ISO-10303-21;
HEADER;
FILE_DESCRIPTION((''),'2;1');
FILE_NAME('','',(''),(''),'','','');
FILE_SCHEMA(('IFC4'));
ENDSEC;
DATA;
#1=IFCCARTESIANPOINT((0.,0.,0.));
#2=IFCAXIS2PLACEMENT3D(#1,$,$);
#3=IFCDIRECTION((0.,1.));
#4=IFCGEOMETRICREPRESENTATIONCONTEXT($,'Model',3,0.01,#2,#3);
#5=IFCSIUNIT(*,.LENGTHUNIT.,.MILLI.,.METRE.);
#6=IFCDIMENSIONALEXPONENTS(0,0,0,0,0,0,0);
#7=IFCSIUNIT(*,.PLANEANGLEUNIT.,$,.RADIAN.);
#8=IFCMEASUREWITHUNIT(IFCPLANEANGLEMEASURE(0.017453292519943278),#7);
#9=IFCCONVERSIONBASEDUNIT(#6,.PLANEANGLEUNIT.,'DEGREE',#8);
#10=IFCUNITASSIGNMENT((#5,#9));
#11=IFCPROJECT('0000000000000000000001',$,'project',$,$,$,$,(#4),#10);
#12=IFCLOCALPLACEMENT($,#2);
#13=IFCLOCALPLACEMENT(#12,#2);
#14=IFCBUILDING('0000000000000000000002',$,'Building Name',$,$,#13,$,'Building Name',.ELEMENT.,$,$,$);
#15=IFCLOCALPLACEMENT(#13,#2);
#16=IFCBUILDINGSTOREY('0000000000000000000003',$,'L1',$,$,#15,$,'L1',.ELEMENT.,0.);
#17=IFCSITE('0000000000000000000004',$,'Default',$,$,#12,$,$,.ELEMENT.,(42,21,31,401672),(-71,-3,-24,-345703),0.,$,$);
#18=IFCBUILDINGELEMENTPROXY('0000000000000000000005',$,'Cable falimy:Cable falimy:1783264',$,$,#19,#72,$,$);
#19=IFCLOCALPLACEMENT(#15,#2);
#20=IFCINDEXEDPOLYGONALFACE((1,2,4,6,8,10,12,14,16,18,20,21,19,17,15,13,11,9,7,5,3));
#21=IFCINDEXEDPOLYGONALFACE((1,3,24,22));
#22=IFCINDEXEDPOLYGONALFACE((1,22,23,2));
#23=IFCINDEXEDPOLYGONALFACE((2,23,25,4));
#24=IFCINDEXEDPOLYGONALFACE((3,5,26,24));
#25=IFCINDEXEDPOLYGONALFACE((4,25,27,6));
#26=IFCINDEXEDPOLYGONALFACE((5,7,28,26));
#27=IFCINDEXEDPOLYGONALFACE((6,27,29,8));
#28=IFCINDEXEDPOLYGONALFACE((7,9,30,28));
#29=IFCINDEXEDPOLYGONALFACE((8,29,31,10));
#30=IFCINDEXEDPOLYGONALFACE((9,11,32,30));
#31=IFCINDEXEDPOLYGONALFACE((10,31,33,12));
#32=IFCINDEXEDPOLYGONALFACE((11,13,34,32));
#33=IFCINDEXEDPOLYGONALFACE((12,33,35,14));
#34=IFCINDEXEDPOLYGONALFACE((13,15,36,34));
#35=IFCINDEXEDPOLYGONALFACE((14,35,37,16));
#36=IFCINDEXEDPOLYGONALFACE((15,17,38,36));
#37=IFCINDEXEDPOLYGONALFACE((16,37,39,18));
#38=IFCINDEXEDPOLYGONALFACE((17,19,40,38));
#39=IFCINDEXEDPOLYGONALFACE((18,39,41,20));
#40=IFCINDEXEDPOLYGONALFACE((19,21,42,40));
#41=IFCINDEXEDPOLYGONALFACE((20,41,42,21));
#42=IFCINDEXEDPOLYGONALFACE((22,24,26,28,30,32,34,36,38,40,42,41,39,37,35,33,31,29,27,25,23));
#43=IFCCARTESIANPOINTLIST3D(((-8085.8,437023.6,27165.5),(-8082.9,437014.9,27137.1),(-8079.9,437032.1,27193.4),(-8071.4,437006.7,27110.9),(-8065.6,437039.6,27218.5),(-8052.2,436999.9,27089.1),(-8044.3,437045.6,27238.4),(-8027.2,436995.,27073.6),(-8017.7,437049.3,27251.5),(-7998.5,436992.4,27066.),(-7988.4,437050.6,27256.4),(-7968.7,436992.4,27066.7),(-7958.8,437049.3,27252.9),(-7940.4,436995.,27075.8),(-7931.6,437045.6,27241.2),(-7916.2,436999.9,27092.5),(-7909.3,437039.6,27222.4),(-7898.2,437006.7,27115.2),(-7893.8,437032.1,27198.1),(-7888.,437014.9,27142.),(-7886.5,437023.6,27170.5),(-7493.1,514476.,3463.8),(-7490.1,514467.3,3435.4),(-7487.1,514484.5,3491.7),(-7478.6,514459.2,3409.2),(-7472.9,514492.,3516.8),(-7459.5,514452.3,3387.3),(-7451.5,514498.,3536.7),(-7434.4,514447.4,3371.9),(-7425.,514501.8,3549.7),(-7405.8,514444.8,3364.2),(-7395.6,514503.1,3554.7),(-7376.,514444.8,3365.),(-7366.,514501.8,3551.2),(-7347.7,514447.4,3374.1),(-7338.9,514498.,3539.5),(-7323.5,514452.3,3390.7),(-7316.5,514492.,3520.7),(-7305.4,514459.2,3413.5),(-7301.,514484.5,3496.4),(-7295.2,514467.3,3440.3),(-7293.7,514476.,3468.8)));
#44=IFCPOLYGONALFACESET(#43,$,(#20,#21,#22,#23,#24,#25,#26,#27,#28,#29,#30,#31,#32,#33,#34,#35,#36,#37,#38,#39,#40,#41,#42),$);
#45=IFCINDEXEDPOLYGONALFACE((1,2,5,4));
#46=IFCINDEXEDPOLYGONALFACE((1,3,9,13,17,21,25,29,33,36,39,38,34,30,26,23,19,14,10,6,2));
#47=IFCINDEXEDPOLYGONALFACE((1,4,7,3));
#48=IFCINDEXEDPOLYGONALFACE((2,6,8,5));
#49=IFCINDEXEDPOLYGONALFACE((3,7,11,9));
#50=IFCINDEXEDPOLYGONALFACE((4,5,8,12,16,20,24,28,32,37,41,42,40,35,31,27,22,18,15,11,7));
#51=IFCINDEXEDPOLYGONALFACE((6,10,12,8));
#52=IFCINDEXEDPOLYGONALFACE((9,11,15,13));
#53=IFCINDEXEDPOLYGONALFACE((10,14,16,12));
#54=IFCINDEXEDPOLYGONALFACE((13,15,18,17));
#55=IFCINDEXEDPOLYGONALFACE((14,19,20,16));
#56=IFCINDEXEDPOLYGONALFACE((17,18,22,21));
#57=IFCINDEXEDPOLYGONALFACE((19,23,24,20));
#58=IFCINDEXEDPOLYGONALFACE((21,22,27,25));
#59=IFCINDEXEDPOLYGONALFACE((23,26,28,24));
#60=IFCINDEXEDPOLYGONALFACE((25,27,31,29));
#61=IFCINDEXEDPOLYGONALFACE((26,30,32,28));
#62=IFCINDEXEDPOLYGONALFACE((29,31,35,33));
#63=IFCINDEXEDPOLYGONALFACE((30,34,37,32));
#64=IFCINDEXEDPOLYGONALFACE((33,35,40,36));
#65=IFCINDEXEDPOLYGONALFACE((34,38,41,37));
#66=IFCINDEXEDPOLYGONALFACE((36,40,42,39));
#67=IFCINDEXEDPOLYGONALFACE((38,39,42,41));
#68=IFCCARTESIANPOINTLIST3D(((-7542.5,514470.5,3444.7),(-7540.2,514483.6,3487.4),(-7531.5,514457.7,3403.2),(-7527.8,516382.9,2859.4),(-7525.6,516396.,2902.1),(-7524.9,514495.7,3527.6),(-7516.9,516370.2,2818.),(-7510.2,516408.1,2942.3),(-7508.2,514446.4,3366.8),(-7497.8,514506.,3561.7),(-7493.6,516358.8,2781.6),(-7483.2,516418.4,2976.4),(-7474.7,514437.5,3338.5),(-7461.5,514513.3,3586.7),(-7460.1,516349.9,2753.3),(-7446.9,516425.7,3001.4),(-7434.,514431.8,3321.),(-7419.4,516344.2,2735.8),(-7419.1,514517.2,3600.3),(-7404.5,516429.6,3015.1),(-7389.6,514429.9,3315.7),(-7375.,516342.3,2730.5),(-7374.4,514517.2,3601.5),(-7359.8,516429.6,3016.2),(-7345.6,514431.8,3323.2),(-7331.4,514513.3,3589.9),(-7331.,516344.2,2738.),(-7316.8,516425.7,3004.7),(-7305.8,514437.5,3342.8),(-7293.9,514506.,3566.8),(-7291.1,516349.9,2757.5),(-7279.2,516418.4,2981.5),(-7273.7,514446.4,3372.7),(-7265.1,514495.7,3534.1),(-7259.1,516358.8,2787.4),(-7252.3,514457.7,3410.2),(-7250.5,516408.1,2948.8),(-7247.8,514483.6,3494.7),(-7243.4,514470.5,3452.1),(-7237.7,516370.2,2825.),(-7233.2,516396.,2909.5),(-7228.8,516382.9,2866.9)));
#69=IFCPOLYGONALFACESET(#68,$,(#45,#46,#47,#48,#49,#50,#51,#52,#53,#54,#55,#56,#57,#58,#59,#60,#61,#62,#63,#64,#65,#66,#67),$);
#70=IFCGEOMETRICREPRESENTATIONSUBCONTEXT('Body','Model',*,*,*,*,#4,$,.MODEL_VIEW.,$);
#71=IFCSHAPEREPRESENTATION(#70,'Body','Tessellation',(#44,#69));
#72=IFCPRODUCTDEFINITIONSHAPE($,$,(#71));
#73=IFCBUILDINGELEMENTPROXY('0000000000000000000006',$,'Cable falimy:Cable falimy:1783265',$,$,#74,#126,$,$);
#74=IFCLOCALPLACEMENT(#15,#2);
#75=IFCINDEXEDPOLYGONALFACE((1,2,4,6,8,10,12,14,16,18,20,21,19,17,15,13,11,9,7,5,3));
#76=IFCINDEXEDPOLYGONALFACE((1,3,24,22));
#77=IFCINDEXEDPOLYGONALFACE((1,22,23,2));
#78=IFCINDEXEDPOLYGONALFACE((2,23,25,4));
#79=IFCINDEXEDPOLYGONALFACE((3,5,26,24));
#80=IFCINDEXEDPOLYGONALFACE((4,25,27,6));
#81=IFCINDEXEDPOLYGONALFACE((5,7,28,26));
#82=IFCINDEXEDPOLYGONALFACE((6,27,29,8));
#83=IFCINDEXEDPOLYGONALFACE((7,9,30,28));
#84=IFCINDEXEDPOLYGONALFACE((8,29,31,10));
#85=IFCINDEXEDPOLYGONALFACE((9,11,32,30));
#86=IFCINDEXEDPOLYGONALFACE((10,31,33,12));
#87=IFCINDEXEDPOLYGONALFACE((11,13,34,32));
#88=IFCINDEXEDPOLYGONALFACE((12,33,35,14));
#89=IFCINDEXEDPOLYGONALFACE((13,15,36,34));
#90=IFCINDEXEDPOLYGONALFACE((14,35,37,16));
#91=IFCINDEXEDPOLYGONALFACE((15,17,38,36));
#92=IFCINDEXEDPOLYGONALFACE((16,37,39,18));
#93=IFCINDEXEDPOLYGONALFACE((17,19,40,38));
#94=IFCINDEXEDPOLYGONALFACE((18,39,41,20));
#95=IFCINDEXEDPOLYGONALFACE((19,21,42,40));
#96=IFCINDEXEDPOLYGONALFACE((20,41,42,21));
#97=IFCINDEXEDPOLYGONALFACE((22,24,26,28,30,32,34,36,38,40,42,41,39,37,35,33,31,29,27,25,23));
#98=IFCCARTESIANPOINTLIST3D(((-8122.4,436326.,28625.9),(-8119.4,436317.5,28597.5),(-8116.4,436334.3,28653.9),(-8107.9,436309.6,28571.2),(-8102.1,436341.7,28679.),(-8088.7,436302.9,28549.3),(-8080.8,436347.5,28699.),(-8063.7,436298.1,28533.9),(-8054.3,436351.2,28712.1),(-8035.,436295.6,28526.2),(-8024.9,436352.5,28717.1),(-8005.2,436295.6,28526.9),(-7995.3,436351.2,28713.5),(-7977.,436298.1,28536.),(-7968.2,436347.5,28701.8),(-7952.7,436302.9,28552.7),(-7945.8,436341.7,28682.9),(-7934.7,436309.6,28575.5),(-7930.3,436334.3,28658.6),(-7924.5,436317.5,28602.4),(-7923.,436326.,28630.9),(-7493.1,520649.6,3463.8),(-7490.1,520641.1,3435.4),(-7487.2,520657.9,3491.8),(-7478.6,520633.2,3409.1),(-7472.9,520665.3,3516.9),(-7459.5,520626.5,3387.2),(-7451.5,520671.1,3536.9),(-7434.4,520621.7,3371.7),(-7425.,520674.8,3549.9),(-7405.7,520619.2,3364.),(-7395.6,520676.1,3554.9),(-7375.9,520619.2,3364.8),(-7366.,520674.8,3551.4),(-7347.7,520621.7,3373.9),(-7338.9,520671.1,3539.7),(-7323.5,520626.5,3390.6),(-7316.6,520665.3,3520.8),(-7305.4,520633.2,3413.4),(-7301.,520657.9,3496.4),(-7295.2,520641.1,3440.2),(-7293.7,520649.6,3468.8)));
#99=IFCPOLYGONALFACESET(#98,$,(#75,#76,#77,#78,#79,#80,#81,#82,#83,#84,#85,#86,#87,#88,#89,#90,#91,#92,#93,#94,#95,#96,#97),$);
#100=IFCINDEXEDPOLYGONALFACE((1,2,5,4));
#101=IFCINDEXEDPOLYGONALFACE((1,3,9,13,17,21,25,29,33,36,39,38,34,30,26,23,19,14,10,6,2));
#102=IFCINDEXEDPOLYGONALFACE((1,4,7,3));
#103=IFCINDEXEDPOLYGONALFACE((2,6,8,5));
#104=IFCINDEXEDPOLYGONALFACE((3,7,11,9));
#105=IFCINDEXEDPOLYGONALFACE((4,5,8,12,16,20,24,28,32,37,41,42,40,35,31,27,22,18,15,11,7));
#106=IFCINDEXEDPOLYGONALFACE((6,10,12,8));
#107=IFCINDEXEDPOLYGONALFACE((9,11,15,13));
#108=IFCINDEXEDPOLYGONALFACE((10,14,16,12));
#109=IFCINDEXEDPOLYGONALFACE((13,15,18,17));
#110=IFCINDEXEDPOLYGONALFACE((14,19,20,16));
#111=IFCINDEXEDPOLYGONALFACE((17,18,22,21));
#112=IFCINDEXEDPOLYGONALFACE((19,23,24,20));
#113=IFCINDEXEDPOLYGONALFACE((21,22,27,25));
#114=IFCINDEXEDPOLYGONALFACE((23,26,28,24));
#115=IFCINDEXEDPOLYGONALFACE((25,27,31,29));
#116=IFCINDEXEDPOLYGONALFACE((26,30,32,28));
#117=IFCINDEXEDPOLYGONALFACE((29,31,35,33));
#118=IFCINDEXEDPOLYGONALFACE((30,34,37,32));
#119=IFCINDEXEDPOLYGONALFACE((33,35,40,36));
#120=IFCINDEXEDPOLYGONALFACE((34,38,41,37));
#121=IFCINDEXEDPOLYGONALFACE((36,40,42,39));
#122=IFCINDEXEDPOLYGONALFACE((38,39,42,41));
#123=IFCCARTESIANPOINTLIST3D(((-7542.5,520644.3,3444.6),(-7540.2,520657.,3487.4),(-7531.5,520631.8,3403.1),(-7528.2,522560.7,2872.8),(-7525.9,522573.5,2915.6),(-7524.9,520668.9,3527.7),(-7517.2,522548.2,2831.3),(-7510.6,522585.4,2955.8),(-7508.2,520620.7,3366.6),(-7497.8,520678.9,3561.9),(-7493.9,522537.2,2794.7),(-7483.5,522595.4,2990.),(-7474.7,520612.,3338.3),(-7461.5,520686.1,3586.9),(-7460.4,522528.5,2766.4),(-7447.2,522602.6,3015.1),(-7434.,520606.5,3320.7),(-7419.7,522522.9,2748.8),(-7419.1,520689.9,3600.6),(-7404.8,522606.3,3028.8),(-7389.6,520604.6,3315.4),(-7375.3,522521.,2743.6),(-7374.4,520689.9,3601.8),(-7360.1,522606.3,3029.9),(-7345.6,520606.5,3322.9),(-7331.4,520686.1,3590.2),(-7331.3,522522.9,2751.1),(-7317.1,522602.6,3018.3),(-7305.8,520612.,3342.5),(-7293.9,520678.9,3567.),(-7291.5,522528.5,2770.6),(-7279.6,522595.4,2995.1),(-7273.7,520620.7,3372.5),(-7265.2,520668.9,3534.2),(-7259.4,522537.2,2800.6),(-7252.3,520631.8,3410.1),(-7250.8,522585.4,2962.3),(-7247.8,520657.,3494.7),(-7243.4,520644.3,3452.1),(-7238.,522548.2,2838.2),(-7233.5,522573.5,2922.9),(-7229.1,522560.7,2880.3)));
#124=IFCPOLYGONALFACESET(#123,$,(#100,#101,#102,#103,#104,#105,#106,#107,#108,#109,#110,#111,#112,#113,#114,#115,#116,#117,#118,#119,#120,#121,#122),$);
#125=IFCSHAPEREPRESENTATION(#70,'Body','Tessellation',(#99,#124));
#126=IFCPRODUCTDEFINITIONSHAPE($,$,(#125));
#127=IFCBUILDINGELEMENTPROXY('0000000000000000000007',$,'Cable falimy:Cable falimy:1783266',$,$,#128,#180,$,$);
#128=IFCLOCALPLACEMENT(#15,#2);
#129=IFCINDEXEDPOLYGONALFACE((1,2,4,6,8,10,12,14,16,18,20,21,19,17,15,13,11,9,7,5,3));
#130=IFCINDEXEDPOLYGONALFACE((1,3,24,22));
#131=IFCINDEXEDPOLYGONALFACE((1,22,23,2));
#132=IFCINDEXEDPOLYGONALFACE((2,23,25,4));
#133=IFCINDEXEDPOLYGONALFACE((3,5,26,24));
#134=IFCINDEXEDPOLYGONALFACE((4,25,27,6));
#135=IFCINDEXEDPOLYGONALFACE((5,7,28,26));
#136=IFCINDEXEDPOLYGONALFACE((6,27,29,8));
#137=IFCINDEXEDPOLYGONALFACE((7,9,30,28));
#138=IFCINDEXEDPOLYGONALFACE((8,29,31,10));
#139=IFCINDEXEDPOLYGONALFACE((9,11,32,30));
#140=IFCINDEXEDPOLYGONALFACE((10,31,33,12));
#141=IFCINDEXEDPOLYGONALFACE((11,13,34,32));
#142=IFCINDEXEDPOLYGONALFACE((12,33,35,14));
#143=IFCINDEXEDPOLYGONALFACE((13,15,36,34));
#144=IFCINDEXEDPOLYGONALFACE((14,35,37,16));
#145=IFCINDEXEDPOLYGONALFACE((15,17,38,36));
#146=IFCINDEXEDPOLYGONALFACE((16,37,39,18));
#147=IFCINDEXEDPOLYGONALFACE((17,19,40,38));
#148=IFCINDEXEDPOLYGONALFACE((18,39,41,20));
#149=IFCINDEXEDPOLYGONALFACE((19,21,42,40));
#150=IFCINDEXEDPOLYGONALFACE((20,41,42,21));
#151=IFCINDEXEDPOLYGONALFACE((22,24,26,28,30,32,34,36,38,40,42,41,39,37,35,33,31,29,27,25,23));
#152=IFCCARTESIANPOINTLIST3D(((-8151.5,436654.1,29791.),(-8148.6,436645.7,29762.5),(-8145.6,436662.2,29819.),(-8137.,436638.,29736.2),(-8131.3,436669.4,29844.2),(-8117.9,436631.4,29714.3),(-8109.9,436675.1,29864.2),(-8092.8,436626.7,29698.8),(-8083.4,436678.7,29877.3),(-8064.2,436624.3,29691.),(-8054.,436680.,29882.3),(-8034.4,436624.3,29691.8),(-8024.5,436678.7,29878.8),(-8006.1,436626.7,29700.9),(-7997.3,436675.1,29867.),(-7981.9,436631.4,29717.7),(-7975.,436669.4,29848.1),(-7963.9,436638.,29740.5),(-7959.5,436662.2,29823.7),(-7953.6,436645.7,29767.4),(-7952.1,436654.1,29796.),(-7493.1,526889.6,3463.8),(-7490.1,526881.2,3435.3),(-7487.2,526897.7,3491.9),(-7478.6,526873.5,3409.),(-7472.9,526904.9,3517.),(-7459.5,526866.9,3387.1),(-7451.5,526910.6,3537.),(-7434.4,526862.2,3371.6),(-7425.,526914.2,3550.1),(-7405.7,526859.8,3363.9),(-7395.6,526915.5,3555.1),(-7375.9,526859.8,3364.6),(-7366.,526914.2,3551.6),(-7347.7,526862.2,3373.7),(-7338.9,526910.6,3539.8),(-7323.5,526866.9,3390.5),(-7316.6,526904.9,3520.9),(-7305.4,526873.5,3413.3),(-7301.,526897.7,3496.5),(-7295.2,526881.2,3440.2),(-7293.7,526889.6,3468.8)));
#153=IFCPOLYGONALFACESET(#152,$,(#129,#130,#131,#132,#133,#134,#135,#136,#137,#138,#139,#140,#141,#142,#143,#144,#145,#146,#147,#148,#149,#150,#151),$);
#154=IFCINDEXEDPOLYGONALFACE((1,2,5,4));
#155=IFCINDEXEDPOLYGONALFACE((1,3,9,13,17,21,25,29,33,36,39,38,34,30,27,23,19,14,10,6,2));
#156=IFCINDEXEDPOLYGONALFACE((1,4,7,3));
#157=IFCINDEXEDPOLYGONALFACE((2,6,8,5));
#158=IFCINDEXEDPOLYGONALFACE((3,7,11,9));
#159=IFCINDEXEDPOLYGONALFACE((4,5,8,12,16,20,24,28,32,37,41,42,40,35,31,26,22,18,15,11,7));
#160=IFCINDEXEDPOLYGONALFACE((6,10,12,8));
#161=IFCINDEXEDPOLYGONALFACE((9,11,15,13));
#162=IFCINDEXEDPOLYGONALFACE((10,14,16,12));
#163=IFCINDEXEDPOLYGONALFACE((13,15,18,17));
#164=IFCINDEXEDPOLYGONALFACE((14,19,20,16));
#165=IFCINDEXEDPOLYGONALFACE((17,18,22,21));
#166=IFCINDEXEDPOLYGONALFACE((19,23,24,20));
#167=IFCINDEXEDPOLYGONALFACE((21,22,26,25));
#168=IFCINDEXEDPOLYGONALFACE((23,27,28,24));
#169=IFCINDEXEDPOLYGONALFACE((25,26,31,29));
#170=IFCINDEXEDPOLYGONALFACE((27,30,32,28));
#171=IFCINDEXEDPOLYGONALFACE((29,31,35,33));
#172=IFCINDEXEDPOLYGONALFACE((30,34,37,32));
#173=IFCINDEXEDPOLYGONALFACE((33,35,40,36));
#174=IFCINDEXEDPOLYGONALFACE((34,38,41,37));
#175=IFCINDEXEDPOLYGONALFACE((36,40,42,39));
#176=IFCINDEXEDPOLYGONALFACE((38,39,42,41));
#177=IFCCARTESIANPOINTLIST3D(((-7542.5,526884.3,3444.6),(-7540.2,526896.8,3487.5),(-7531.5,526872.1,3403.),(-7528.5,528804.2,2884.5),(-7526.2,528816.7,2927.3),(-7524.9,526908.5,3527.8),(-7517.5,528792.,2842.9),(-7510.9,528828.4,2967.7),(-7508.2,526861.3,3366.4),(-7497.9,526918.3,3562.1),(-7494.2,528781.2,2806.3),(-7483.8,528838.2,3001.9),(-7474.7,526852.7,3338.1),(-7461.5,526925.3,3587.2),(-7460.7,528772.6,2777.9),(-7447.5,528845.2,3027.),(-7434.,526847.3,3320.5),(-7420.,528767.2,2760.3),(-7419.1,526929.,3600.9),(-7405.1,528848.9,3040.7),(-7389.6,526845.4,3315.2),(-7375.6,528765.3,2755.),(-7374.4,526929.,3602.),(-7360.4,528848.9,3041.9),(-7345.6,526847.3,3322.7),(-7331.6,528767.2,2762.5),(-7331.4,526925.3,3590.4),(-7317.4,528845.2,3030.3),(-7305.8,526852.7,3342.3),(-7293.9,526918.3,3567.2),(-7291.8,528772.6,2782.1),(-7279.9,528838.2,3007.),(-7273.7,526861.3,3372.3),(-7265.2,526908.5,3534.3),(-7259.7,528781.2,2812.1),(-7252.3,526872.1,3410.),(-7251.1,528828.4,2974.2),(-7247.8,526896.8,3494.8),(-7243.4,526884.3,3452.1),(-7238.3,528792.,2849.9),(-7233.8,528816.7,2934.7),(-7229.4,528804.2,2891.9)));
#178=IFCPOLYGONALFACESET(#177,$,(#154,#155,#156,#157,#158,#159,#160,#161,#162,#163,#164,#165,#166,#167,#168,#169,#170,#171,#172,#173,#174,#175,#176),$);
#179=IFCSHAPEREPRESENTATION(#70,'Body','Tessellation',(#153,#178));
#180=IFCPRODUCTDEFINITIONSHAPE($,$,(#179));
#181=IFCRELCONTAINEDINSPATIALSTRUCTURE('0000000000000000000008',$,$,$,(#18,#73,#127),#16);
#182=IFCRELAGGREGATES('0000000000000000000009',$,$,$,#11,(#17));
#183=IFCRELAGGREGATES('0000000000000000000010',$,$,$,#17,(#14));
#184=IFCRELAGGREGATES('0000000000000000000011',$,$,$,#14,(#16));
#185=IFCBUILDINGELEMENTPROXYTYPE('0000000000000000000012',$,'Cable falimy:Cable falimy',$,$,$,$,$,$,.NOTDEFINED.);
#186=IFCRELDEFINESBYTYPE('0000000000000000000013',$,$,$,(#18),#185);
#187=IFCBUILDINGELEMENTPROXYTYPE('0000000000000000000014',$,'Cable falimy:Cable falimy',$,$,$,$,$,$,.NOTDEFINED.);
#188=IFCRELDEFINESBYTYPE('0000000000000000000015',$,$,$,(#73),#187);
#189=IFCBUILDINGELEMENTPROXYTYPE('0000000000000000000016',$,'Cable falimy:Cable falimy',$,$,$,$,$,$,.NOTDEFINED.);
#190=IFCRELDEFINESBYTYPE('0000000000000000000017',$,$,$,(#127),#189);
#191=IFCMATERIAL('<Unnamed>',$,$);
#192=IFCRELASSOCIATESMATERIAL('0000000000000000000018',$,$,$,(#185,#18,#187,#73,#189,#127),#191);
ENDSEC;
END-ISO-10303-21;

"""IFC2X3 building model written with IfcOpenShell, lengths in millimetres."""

from ifc_helpers import new_model, entity, si_unit, converted_unit, direction, frame, frame_2d, origin, place, context, subcontext, project, spatial, circle, extrude, source, transform, mapped, material, type_object, type_shapes, element, save


model = new_model("IFC2X3")

# Units and contexts
model_context = context("Model", 3, precision=0.01, world=origin(), true_north=direction((0.0, 1.0)))
body_context = subcontext(model_context, "Body", "Model", "MODEL_VIEW")
ifc_project = project(units=[si_unit("LENGTHUNIT", "METRE", prefix="MILLI"), converted_unit("PLANEANGLEUNIT", "DEGREE", entity("IfcPlaneAngleMeasure", 0.017453292519943278), si_unit("PLANEANGLEUNIT", "RADIAN"), dimensions=[0, 0, 0, 0, 0, 0, 0])], contexts=[model_context])

# Site, building, storey
site_placement = place(None, origin())
site = spatial("IfcSite", under=ifc_project, at=site_placement, Name="Default", CompositionType="ELEMENT", RefLatitude=(42, 21, 31, 401672), RefLongitude=(-71, -3, -24, -345703), RefElevation=0.0)
building_placement = place(site_placement, origin())
building = spatial("IfcBuilding", under=site, at=building_placement, Name="Building Name", LongName="Building Name", CompositionType="ELEMENT")
storey_placement = place(building_placement, origin())
storey = spatial("IfcBuildingStorey", under=building, at=storey_placement, Name="L1", LongName="L1", CompositionType="ELEMENT", Elevation=0.0)

# Shared definitions
ifc_material = material(Name="<Unnamed>")

# Building element proxies
building_element_proxy_type_1 = type_object("IfcBuildingElementProxyType", Name="Cable falimy:Cable falimy", PredefinedType="NOTDEFINED", material=ifc_material)
shared_shape_1 = source(origin(), body_context, "Body", "SweptSolid", [
    extrude(circle(Radius=100.0, at=frame_2d((0.0, 0.0), x_axis=(1.0, 0.0))), frame((0.0, 0.0, 0.0), z_axis=(0.956203, 0.0, 0.292706), x_axis=(-0.292706, 0.0, 0.956203)), (0.0, 0.0, 1.0), 81000.0),
    extrude(circle(Radius=150.0, at=frame_2d((0.0, 0.0), x_axis=(1.0, 0.0))), frame((-1912.4, 0.0, -585.4), z_axis=(0.956203, 0.0, 0.292706), x_axis=(0.292706, 0.0, -0.956203)), (0.0, 0.0, 1.0), 2000.0),
])
type_shapes(building_element_proxy_type_1, [shared_shape_1])
proxy_1_placement = place(storey_placement, frame((-7393.2, 514473.8, 3459.1), z_axis=(-0.025001, 0.0, 0.999687), x_axis=(0.0, -1.0, 0.0)))
element("IfcBuildingElementProxy", 1, at=proxy_1_placement, inside=storey, type_object=building_element_proxy_type_1, material=ifc_material, Name="Cable falimy:Cable falimy:1783264", context=body_context, shape_type="MappedRepresentation", body=[
    mapped(shared_shape_1, transform((0.0, 0.0, 0.0), scale=1.0)),
])
building_element_proxy_type_2 = type_object("IfcBuildingElementProxyType", Name="Cable falimy:Cable falimy", PredefinedType="NOTDEFINED", material=ifc_material)
shared_shape_2 = source(origin(), body_context, "Body", "SweptSolid", [
    extrude(circle(Radius=100.0, at=frame_2d((0.0, 0.0), x_axis=(1.0, 0.0))), frame((0.0, 0.0, 0.0), z_axis=(0.958223, 0.0, 0.286023), x_axis=(-0.286023, 0.0, 0.958223)), (0.0, 0.0, 1.0), 88000.0),
    extrude(circle(Radius=150.0, at=frame_2d((0.0, 0.0), x_axis=(1.0, 0.0))), frame((-1916.4, 0.0, -572.0), z_axis=(0.958223, 0.0, 0.286023), x_axis=(0.286023, 0.0, -0.958223)), (0.0, 0.0, 1.0), 2000.0),
])
type_shapes(building_element_proxy_type_2, [shared_shape_2])
proxy_2_placement = place(storey_placement, frame((-7393.2, 520647.5, 3459.1), z_axis=(-0.025001, 0.0, 0.999687), x_axis=(0.0, -1.0, 0.0)))
element("IfcBuildingElementProxy", 2, at=proxy_2_placement, inside=storey, type_object=building_element_proxy_type_2, material=ifc_material, Name="Cable falimy:Cable falimy:1783265", context=body_context, shape_type="MappedRepresentation", body=[
    mapped(shared_shape_2, transform((0.0, 0.0, 0.0), scale=1.0)),
])
building_element_proxy_type_3 = type_object("IfcBuildingElementProxyType", Name="Cable falimy:Cable falimy", PredefinedType="NOTDEFINED", material=ifc_material)
shared_shape_3 = source(origin(), body_context, "Body", "SweptSolid", [
    extrude(circle(Radius=100.0, at=frame_2d((0.0, 0.0), x_axis=(1.0, 0.0))), frame((0.0, 0.0, 0.0), z_axis=(0.959952, 0.0, 0.280164), x_axis=(-0.280164, 0.0, 0.959952)), (0.0, 0.0, 1.0), 94000.0),
    extrude(circle(Radius=150.0, at=frame_2d((0.0, 0.0), x_axis=(1.0, 0.0))), frame((-1919.9, 0.0, -560.3), z_axis=(0.959952, 0.0, 0.280164), x_axis=(0.280164, 0.0, -0.959952)), (0.0, 0.0, 1.0), 2000.0),
])
type_shapes(building_element_proxy_type_3, [shared_shape_3])
proxy_3_placement = place(storey_placement, frame((-7393.2, 526887.5, 3459.1), z_axis=(-0.025001, 0.0, 0.999687), x_axis=(0.0, -1.0, 0.0)))
element("IfcBuildingElementProxy", 3, at=proxy_3_placement, inside=storey, type_object=building_element_proxy_type_3, material=ifc_material, Name="Cable falimy:Cable falimy:1783266", context=body_context, shape_type="MappedRepresentation", body=[
    mapped(shared_shape_3, transform((0.0, 0.0, 0.0), scale=1.0)),
])

save(model, "model.ifc")
